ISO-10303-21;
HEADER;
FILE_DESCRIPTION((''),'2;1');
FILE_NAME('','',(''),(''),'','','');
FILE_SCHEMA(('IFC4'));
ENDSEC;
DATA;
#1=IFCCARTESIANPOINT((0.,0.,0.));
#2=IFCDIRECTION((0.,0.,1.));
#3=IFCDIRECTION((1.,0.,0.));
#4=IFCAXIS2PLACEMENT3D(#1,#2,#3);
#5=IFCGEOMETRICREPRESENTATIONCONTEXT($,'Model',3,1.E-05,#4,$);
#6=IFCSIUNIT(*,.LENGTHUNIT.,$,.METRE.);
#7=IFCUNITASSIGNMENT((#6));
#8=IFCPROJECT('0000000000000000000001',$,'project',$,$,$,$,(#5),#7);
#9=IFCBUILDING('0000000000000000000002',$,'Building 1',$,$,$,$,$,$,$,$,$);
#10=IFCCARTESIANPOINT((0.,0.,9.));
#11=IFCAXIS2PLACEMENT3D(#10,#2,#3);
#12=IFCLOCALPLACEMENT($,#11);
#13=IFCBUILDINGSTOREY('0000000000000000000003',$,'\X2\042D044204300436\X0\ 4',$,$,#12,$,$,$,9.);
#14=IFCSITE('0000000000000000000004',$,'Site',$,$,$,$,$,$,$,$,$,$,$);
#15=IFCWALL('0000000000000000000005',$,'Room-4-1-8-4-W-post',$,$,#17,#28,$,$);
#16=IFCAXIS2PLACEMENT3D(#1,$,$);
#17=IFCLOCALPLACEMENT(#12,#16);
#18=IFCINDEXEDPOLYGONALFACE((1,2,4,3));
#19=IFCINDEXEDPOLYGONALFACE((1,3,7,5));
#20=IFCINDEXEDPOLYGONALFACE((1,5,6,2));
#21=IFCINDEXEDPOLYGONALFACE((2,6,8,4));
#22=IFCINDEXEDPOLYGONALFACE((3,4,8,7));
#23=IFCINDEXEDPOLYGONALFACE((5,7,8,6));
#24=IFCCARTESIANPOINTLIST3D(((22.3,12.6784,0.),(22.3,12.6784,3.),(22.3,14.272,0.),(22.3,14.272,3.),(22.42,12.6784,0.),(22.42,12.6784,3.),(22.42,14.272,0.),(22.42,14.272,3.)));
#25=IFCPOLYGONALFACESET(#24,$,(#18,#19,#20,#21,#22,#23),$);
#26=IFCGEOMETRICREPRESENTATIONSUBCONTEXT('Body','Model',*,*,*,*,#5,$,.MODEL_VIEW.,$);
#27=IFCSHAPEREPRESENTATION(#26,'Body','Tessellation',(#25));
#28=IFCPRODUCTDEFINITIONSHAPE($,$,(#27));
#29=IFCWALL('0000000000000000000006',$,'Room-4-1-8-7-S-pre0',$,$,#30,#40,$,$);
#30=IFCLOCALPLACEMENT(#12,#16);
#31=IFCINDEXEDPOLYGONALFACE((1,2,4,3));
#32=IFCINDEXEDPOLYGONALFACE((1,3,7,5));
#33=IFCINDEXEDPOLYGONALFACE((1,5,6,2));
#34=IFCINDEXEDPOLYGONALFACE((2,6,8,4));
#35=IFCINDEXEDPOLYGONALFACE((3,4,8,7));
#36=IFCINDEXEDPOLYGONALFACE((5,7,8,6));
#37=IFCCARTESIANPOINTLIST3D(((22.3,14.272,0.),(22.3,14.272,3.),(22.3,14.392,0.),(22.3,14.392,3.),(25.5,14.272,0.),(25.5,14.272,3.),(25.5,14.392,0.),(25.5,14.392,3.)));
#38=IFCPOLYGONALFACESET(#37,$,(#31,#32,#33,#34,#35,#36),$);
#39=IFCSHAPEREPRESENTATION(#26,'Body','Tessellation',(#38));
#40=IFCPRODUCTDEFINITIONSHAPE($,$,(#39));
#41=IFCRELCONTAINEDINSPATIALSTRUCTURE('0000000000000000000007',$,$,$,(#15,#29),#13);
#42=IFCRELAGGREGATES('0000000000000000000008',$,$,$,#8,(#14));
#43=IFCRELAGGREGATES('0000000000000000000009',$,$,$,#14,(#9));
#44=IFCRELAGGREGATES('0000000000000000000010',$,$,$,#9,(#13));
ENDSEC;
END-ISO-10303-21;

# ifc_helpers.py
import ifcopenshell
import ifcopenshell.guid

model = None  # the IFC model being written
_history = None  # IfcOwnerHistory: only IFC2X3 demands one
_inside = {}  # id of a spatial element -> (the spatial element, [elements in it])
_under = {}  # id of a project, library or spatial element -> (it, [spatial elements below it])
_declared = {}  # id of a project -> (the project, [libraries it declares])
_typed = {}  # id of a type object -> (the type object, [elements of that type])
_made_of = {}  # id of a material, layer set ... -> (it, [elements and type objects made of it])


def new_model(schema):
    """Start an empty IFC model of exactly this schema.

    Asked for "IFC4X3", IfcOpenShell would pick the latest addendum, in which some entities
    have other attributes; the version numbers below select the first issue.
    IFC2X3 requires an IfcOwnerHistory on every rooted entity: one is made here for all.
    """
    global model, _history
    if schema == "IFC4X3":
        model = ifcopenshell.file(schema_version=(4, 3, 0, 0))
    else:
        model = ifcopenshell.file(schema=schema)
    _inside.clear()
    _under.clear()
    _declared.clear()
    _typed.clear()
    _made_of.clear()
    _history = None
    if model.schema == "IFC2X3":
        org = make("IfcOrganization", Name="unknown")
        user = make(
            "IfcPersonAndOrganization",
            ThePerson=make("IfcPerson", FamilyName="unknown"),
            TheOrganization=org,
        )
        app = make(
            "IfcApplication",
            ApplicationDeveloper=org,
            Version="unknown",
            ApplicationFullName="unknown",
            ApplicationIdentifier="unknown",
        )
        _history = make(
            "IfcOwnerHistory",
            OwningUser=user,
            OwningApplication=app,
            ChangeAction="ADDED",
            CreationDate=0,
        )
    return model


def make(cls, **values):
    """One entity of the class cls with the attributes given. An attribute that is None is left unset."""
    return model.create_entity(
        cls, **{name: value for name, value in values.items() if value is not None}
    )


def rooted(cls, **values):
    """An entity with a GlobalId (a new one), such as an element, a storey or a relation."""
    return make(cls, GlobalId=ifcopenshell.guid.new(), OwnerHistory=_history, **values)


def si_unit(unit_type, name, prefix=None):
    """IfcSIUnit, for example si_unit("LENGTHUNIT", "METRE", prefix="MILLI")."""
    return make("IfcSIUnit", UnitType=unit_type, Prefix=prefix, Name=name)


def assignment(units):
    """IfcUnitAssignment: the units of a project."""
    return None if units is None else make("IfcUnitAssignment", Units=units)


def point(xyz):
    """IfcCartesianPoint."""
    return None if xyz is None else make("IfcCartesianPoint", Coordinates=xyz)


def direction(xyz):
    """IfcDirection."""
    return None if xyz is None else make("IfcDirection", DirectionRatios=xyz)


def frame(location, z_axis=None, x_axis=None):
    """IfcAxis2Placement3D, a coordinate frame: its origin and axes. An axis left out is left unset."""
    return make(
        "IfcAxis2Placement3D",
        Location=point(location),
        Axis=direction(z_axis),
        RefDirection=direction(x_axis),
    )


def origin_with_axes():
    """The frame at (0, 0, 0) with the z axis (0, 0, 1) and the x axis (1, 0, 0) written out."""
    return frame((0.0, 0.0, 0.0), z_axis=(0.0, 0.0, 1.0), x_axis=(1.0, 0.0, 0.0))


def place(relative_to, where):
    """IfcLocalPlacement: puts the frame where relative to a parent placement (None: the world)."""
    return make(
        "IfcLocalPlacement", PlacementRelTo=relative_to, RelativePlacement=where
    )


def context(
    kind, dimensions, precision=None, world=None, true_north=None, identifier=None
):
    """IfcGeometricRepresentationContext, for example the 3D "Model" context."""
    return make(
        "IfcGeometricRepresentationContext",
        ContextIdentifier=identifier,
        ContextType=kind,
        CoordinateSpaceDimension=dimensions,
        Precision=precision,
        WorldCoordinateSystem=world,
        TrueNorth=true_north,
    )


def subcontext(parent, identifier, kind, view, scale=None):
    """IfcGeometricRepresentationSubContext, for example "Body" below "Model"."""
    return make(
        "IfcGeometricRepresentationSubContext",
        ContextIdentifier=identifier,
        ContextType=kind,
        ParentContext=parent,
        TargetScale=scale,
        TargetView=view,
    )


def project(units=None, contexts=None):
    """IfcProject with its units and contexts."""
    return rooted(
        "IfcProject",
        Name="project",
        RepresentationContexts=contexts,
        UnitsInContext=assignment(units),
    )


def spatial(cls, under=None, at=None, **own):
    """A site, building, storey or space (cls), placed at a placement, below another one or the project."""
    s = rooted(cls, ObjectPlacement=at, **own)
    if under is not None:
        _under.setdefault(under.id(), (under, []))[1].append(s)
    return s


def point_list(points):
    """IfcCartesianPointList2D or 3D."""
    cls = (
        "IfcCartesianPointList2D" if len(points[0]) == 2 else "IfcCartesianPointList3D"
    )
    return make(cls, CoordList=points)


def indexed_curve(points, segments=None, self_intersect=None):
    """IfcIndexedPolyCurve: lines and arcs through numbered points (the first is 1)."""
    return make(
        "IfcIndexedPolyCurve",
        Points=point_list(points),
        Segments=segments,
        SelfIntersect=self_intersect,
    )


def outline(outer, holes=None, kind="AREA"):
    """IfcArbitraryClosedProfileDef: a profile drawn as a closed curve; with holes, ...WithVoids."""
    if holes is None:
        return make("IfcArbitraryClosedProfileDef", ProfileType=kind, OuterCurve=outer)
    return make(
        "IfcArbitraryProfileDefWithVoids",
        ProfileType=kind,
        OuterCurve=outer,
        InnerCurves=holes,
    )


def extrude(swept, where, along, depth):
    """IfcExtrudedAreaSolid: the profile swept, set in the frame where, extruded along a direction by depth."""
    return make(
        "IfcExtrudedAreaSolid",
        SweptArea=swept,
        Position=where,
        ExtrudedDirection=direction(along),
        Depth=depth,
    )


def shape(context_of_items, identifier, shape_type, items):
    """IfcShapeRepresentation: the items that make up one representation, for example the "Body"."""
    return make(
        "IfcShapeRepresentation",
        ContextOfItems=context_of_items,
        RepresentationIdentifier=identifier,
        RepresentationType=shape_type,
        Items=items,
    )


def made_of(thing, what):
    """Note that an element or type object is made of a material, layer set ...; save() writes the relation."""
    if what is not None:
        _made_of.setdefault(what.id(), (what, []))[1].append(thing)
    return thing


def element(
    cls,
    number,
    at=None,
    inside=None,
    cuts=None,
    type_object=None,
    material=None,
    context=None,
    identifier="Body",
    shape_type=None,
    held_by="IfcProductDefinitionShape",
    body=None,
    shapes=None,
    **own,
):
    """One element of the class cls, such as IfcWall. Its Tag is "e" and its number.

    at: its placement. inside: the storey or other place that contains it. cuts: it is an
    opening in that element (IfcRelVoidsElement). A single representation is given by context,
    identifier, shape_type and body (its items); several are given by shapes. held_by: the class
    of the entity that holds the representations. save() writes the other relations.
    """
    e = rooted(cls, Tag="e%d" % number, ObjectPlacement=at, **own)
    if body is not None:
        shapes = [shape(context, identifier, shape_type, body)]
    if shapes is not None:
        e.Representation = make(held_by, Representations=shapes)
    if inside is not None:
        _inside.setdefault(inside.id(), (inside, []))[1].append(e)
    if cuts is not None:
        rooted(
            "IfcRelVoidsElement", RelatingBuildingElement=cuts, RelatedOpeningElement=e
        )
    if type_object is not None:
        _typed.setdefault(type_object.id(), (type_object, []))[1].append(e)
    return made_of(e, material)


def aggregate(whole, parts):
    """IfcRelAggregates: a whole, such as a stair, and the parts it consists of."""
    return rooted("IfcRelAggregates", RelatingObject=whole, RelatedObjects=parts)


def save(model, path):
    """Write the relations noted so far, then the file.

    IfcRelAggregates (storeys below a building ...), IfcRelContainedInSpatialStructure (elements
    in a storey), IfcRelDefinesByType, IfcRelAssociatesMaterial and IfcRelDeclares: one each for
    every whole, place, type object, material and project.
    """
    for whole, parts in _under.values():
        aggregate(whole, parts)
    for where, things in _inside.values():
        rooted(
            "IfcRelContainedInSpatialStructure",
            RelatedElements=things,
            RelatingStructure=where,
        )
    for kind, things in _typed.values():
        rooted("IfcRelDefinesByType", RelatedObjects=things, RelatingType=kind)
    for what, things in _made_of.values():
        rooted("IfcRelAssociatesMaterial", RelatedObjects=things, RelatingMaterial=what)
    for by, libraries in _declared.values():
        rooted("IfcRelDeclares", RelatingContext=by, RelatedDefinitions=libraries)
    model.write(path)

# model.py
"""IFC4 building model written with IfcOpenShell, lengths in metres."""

from ifc_helpers import new_model, si_unit, frame, origin_with_axes, place, context, subcontext, project, spatial, indexed_curve, outline, extrude, element, save


model = new_model("IFC4")

# Units and contexts
model_context = context("Model", 3, precision=1e-05, world=origin_with_axes())
body_context = subcontext(model_context, "Body", "Model", "MODEL_VIEW")
ifc_project = project(units=[si_unit("LENGTHUNIT", "METRE")], contexts=[model_context])

# Site, building, storey
site = spatial("IfcSite", under=ifc_project, Name="Site")
building = spatial("IfcBuilding", under=site, Name="Building 1")
storey_placement = place(None, frame((0.0, 0.0, 9.0), z_axis=(0.0, 0.0, 1.0), x_axis=(1.0, 0.0, 0.0)))
storey = spatial("IfcBuildingStorey", under=building, at=storey_placement, Name="Этаж 4", Elevation=9.0)

# Walls
wall_1_placement = place(storey_placement, frame((22.3, 14.272, 0.0), z_axis=(0.0, 0.0, 1.0), x_axis=(0.0, -1.0, 0.0)))
element("IfcWall", 1, at=wall_1_placement, inside=storey, Name="Room-4-1-8-4-W-post", context=body_context, shape_type="SweptSolid", body=[
    extrude(outline(indexed_curve([(0.0, 0.0), (0.0, 0.12), (1.5936, 0.12), (1.5936, 0.0), (0.0, 0.0)], self_intersect=False)), origin_with_axes(), (0.0, 0.0, 1.0), 3.0),
])
wall_2_placement = place(storey_placement, frame((22.3, 14.272, 0.0), z_axis=(0.0, 0.0, 1.0), x_axis=(1.0, 0.0, 0.0)))
element("IfcWall", 2, at=wall_2_placement, inside=storey, Name="Room-4-1-8-7-S-pre0", context=body_context, shape_type="SweptSolid", body=[
    extrude(outline(indexed_curve([(0.0, 0.0), (0.0, 0.12), (3.2, 0.12), (3.2, 0.0), (0.0, 0.0)], self_intersect=False)), origin_with_axes(), (0.0, 0.0, 1.0), 3.0),
])

save(model, "model.ifc")
